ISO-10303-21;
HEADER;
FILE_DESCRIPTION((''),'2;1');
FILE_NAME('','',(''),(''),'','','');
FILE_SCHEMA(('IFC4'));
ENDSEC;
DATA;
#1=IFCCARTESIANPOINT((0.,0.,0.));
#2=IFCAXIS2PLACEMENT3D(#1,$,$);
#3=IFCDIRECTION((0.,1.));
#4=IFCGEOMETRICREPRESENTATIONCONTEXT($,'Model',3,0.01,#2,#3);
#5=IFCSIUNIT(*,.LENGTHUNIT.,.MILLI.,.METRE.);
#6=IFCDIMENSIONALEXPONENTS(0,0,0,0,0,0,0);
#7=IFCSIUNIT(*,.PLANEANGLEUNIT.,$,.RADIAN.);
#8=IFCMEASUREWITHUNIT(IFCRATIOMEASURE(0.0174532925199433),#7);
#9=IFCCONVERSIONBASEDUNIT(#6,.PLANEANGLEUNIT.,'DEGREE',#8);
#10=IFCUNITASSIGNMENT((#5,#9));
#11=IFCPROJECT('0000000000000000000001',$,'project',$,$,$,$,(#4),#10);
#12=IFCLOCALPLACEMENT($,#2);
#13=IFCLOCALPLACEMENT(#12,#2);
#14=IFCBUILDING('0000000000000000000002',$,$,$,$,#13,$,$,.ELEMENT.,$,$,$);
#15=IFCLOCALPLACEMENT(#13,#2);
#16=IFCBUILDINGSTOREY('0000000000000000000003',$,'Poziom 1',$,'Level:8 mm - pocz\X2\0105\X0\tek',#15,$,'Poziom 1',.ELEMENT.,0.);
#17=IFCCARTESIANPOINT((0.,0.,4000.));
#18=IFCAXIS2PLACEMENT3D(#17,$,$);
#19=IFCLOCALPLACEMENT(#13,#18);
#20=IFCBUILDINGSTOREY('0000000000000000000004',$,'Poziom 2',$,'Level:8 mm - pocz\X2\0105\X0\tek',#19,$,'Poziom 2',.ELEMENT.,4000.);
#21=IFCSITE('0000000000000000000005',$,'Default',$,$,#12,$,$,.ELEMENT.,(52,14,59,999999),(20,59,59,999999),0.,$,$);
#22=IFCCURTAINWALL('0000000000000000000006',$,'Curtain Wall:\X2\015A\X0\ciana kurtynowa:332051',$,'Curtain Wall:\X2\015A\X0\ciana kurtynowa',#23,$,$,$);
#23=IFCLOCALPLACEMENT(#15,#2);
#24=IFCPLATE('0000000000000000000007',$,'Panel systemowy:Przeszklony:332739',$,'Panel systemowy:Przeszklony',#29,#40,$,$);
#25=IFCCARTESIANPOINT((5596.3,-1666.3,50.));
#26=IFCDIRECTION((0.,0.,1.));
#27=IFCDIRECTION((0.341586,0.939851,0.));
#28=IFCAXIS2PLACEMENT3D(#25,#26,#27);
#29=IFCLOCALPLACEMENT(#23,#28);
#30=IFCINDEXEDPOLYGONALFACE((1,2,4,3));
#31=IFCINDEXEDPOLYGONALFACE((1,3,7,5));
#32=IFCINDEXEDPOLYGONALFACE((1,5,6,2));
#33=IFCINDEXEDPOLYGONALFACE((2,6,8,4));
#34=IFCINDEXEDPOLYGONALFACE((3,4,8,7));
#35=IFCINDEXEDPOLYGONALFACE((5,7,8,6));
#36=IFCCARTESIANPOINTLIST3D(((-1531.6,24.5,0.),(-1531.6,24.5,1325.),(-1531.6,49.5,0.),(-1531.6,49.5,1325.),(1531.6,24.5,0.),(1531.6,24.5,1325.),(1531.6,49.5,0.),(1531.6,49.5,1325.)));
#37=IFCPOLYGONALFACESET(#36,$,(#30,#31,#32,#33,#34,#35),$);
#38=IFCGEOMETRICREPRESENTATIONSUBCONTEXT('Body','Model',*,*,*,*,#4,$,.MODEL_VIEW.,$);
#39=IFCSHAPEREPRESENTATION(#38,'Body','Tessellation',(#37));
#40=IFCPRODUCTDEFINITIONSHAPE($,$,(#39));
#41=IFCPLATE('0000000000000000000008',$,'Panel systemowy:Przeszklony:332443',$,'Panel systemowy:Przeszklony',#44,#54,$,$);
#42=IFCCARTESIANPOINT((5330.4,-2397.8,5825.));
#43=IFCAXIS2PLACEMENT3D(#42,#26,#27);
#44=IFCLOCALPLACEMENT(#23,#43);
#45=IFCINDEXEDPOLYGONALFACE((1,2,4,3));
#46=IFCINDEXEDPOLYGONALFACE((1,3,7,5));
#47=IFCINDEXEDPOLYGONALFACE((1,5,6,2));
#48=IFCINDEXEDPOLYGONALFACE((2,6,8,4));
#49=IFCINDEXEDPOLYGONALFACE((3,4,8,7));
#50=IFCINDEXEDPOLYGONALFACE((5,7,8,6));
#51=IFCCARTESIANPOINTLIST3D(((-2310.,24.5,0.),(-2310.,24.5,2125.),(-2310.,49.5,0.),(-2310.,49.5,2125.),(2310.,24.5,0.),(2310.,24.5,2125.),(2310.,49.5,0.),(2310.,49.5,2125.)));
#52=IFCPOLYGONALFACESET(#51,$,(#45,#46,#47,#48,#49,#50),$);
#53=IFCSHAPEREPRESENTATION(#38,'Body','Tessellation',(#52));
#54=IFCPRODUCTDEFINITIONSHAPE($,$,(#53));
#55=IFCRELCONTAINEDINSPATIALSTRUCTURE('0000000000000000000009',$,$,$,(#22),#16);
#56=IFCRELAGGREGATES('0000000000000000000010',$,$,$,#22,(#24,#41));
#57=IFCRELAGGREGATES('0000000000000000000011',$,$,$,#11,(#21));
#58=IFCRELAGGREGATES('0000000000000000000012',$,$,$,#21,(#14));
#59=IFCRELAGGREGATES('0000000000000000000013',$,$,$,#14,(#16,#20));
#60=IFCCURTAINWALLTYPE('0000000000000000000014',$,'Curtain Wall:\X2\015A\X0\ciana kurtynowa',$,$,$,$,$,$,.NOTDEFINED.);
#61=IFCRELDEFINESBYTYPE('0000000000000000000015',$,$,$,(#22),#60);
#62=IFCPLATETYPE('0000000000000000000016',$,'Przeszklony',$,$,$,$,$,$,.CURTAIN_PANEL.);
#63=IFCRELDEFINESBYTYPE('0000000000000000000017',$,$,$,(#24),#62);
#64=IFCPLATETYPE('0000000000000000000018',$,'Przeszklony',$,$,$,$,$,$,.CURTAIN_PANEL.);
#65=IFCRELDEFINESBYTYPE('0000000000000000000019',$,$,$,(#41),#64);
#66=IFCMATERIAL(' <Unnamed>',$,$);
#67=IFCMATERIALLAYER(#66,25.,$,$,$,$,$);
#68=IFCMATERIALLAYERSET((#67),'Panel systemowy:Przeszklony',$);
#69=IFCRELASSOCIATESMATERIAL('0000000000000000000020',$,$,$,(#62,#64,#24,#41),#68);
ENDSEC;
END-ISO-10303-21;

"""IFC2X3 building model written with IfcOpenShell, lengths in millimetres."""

from ifc_helpers import new_model, entity, si_unit, converted_unit, direction, frame, frame_2d, origin, place, context, subcontext, project, spatial, rectangle, extrude, source, transform, mapped, material, layer, layer_set, layer_usage, type_object, type_shapes, element, aggregate, save


model = new_model("IFC2X3")

# Units and contexts
model_context = context("Model", 3, precision=0.01, world=origin(), true_north=direction((0.0, 1.0)))
body_context = subcontext(model_context, "Body", "Model", "MODEL_VIEW")
ifc_project = project(units=[si_unit("LENGTHUNIT", "METRE", prefix="MILLI"), converted_unit("PLANEANGLEUNIT", "DEGREE", entity("IfcRatioMeasure", 0.0174532925199433), si_unit("PLANEANGLEUNIT", "RADIAN"), dimensions=[0, 0, 0, 0, 0, 0, 0])], contexts=[model_context])

# Site, building, storey
site_placement = place(None, origin())
site = spatial("IfcSite", under=ifc_project, at=site_placement, Name="Default", CompositionType="ELEMENT", RefLatitude=(52, 14, 59, 999999), RefLongitude=(20, 59, 59, 999999), RefElevation=0.0)
building_placement = place(site_placement, origin())
building = spatial("IfcBuilding", under=site, at=building_placement, CompositionType="ELEMENT")
storey_1_placement = place(building_placement, origin())
storey_1 = spatial("IfcBuildingStorey", under=building, at=storey_1_placement, Name="Poziom 1", ObjectType="Level:8 mm - początek", LongName="Poziom 1", CompositionType="ELEMENT", Elevation=0.0)

# Curtain wall
curtain_wall_type = type_object("IfcCurtainWallType", Name="Curtain Wall:Ściana kurtynowa", PredefinedType="NOTDEFINED")
curtain_wall_placement = place(storey_1_placement, origin())
curtain_wall = element("IfcCurtainWall", 1, at=curtain_wall_placement, inside=storey_1, type_object=curtain_wall_type, Name="Curtain Wall:Ściana kurtynowa:332051", ObjectType="Curtain Wall:Ściana kurtynowa")

# Plates
ifc_material_1 = material(Name=" <Unnamed>")
ifc_layer_1 = layer(ifc_material_1, 25.0)
ifc_layer_set_1 = layer_set([ifc_layer_1], Name="Panel systemowy:Przeszklony")
ifc_layer_usage_1 = layer_usage(ifc_layer_set_1, "AXIS3", "POSITIVE", 0.1)
plate_type_1 = type_object("IfcPlateType", Name="Przeszklony", PredefinedType="CURTAIN_PANEL", material=ifc_layer_set_1)
shared_shape_1 = source(origin(), body_context, "Body", "SweptSolid", [
    extrude(rectangle(XDim=1325.0, YDim=3063.3, at=frame_2d((0.0, -194.6), x_axis=(1.0, 0.0))), frame((194.6, 24.5, 662.5), z_axis=(0.0, 1.0, 0.0), x_axis=(0.0, 0.0, 1.0)), (0.0, 0.0, 1.0), 25.0),
])
type_shapes(plate_type_1, [shared_shape_1])
plate_1_placement = place(curtain_wall_placement, frame((5596.3, -1666.3, 50.0), z_axis=(0.0, 0.0, 1.0), x_axis=(0.341586, 0.939851, 0.0)))
plate_1 = element("IfcPlate", 2, at=plate_1_placement, type_object=plate_type_1, material=ifc_layer_usage_1, Name="Panel systemowy:Przeszklony:332739", ObjectType="Panel systemowy:Przeszklony", context=body_context, shape_type="MappedRepresentation", body=[
    mapped(shared_shape_1, transform((0.0, 0.0, 0.0), scale=1.0)),
])
ifc_layer_usage_2 = layer_usage(ifc_layer_set_1, "AXIS3", "POSITIVE", 0.1)
plate_type_2 = type_object("IfcPlateType", Name="Przeszklony", PredefinedType="CURTAIN_PANEL", material=ifc_layer_set_1)
shared_shape_2 = source(origin(), body_context, "Body", "SweptSolid", [
    extrude(rectangle(XDim=2125.0, YDim=4619.9, at=frame_2d((0.0, -311.3), x_axis=(1.0, 0.0))), frame((311.3, 24.5, 1062.5), z_axis=(0.0, 1.0, 0.0), x_axis=(0.0, 0.0, 1.0)), (0.0, 0.0, 1.0), 25.0),
])
type_shapes(plate_type_2, [shared_shape_2])
plate_2_placement = place(curtain_wall_placement, frame((5330.4, -2397.8, 5825.0), z_axis=(0.0, 0.0, 1.0), x_axis=(0.341586, 0.939851, 0.0)))
plate_2 = element("IfcPlate", 3, at=plate_2_placement, type_object=plate_type_2, material=ifc_layer_usage_2, Name="Panel systemowy:Przeszklony:332443", ObjectType="Panel systemowy:Przeszklony", context=body_context, shape_type="MappedRepresentation", body=[
    mapped(shared_shape_2, transform((0.0, 0.0, 0.0), scale=1.0)),
])
aggregate(curtain_wall, [plate_1, plate_2])

# Shared definitions
storey_2_placement = place(building_placement, frame((0.0, 0.0, 4000.0)))
storey_2 = spatial("IfcBuildingStorey", under=building, at=storey_2_placement, Name="Poziom 2", ObjectType="Level:8 mm - początek", LongName="Poziom 2", CompositionType="ELEMENT", Elevation=4000.0)

save(model, "model.ifc")
